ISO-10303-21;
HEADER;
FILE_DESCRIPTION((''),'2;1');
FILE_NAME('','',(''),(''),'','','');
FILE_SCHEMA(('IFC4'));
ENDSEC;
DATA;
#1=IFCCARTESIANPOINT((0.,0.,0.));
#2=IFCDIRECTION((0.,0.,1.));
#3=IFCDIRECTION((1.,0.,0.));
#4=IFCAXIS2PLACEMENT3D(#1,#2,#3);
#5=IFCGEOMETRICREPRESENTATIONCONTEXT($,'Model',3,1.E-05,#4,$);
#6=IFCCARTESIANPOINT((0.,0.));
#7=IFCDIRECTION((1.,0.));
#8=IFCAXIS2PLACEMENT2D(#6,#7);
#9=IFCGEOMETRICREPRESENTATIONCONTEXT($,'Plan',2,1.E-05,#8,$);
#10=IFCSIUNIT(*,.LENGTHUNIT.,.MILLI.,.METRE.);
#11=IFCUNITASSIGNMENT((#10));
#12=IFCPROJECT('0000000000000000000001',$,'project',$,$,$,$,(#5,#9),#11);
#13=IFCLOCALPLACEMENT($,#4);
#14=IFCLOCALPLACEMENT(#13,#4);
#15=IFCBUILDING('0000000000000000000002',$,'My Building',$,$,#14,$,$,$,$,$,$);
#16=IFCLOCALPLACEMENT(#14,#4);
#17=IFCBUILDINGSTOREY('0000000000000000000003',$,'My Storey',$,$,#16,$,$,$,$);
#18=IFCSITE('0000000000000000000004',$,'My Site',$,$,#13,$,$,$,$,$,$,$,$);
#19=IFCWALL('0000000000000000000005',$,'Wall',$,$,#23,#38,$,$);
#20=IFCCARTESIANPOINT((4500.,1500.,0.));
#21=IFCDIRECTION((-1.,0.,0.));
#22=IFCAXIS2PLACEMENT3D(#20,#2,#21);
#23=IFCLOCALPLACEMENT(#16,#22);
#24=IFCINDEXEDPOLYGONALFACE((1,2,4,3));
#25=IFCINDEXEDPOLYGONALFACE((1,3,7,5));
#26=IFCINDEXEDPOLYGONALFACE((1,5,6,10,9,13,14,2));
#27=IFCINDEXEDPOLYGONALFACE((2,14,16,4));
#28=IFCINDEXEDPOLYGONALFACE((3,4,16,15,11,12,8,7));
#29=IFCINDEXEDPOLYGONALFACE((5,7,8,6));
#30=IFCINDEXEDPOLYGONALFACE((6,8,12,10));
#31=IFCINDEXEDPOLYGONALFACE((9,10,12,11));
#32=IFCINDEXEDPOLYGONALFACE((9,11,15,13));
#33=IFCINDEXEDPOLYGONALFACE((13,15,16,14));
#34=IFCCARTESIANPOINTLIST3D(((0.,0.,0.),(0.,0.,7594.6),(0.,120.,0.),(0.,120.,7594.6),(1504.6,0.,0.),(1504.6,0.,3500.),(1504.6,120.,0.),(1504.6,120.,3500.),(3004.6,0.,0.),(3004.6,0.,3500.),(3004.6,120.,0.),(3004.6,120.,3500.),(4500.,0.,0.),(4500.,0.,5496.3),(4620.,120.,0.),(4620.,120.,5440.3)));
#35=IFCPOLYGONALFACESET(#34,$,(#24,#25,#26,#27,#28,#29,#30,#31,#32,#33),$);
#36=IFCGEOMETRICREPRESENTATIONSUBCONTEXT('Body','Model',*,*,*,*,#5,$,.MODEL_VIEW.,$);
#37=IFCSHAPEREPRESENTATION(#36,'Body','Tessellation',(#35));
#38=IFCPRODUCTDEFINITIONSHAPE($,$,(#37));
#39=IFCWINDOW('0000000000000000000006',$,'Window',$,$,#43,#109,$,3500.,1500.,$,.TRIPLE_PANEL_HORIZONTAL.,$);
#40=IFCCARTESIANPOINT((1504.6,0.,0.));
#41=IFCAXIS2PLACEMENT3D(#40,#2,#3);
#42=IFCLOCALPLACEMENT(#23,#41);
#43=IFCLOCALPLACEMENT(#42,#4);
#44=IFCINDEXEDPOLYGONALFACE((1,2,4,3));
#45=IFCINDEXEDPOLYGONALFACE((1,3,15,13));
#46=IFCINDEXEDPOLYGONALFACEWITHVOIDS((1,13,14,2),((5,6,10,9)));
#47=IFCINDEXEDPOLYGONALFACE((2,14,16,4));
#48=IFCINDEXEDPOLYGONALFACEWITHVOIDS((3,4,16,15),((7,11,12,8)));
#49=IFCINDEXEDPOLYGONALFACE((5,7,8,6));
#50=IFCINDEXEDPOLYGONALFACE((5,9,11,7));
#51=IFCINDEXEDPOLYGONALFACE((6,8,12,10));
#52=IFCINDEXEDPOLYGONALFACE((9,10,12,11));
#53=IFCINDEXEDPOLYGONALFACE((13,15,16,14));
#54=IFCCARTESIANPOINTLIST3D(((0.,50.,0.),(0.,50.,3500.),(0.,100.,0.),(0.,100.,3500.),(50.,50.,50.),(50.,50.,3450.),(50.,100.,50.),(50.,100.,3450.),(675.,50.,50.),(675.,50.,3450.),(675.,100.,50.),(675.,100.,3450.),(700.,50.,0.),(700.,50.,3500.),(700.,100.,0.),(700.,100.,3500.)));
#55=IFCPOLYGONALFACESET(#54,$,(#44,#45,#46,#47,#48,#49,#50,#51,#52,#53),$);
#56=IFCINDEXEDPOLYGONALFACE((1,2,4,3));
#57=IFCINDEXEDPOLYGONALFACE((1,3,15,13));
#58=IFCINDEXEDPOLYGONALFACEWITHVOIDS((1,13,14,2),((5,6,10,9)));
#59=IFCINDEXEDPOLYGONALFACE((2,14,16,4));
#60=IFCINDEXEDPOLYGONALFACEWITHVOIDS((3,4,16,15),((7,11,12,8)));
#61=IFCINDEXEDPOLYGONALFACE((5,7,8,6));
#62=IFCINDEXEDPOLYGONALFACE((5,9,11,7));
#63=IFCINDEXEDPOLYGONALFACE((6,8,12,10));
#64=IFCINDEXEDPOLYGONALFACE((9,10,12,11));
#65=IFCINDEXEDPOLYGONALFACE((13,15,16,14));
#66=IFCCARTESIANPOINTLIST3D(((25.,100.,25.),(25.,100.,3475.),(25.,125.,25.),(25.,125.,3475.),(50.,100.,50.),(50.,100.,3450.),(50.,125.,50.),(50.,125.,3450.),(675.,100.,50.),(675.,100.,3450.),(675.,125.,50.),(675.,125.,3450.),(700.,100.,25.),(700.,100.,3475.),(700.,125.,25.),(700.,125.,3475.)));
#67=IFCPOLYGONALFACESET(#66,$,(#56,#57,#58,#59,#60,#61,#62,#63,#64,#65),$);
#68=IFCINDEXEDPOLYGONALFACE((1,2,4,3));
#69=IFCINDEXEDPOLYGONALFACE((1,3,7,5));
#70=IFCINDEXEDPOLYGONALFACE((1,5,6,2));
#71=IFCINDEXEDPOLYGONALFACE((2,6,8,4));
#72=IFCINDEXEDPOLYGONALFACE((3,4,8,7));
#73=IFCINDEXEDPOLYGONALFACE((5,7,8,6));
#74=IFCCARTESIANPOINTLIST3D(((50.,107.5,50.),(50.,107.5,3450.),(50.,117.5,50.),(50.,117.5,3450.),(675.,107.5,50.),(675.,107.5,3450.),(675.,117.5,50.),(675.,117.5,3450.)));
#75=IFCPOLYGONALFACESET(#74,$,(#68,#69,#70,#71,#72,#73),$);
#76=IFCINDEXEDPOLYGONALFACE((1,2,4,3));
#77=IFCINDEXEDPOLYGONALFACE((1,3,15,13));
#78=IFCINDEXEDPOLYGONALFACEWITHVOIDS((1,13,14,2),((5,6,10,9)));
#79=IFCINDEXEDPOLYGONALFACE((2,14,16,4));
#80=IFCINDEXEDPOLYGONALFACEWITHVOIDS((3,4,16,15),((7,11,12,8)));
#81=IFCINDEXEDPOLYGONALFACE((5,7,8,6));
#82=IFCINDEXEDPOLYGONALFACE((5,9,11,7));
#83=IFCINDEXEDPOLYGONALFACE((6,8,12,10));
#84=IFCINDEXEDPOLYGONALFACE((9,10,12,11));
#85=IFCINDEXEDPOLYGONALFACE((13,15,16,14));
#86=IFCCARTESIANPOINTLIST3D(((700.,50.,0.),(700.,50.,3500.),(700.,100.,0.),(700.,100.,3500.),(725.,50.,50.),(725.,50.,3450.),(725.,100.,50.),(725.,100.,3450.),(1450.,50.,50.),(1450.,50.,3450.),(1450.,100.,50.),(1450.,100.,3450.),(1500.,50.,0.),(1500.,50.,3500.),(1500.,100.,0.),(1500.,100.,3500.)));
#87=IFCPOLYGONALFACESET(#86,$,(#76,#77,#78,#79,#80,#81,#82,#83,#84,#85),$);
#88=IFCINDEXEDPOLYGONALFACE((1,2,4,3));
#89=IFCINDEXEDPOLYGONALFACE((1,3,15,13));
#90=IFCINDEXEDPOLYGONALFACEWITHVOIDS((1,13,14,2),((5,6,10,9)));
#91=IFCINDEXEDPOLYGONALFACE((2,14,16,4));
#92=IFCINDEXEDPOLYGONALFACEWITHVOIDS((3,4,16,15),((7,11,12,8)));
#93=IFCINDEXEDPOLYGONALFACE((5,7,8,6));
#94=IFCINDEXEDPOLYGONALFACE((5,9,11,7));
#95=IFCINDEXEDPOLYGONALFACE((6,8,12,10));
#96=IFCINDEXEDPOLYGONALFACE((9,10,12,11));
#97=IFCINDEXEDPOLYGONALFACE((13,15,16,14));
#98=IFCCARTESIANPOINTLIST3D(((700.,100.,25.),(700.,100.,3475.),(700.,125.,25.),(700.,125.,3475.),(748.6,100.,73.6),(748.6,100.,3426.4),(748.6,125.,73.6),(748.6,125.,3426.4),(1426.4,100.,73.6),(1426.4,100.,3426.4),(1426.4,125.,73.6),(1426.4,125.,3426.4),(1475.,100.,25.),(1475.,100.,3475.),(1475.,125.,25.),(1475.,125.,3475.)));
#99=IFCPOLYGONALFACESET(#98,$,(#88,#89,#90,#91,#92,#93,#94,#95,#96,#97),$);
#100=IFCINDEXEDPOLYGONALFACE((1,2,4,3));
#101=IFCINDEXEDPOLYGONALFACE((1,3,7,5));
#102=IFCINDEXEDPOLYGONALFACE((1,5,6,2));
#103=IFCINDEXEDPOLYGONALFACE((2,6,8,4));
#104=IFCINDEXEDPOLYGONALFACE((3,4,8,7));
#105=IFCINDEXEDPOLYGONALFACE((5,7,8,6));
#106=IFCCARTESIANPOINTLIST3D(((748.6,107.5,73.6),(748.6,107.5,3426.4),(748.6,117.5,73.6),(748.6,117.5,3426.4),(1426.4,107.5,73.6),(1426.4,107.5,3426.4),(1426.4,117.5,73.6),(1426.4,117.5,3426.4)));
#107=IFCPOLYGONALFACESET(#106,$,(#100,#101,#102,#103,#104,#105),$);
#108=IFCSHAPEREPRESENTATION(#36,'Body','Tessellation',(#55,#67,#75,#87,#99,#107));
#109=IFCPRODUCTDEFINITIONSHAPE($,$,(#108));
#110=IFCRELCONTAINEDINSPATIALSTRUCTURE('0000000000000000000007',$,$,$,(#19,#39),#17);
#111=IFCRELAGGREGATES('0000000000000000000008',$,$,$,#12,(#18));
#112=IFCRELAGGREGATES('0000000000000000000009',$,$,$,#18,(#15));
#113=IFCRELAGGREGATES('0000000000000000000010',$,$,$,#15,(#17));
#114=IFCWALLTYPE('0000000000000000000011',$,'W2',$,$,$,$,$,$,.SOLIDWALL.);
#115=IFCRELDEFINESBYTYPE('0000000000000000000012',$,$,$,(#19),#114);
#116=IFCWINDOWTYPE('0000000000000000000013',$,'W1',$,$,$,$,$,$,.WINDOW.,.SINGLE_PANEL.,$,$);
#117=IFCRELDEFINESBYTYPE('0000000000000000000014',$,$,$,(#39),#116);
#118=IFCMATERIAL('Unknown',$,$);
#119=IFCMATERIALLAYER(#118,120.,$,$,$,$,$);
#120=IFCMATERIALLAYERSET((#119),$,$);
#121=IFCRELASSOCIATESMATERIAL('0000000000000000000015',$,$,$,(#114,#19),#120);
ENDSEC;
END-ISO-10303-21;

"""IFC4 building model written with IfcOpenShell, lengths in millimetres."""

from ifc_helpers import new_model, entity, si_unit, frame, origin_with_axes, origin_2d_with_axis, place, context, subcontext, project, spatial, line, indexed_curve, outline, extrude, shape, source, transform, mapped, material, layer, layer_set, layer_usage, type_object, type_shapes, element, fill, save


model = new_model("IFC4")

# Units and contexts
model_context = context("Model", 3, precision=1e-05, world=origin_with_axes())
plan_context = context("Plan", 2, precision=1e-05, world=origin_2d_with_axis())
body_context_1 = subcontext(model_context, "Body", "Model", "MODEL_VIEW")
body_context_2 = subcontext(plan_context, "Body", "Plan", "PLAN_VIEW")
ifc_project = project(units=[si_unit("LENGTHUNIT", "METRE", prefix="MILLI")], contexts=[model_context, plan_context])

# Site, building, storey
site_placement = place(None, origin_with_axes())
site = spatial("IfcSite", under=ifc_project, at=site_placement, Name="My Site")
building_placement = place(site_placement, origin_with_axes())
building = spatial("IfcBuilding", under=site, at=building_placement, Name="My Building")
storey_placement = place(building_placement, origin_with_axes())
storey = spatial("IfcBuildingStorey", under=building, at=storey_placement, Name="My Storey")

# Shared definitions
ifc_material = material(Name="Unknown")

# Shared definitions
ifc_layer_1 = layer(ifc_material, 120.0)
ifc_layer_set_1 = layer_set([ifc_layer_1])
wall_type_1 = type_object("IfcWallType", Name="W2", PredefinedType="SOLIDWALL", material=ifc_layer_set_1)
shared_shape_1 = source(origin_with_axes(), body_context_1, "Body", "SweptSolid", [
    extrude(outline(indexed_curve([(0.0, 0.0), (1500.0, 0.0), (1500.0, 3500.0), (0.0, 3500.0)], segments=[line(1, 2, 3, 4, 1)])), frame((0.0, -600.0, 0.0), z_axis=(0.0, -1.0, 0.0), x_axis=(1.0, 0.0, 0.0)), (0.0, 0.0, -1.0), 1200.0),
])
window_type_1 = type_object("IfcWindowType", Name="W1", PartitioningType="SINGLE_PANEL", PredefinedType="WINDOW")
shared_shape_2 = source(origin_with_axes(), body_context_1, "Body", "SweptSolid", [
    extrude(outline(indexed_curve([(0.0, 0.0), (700.0, 0.0), (700.0, 3500.0), (0.0, 3500.0)], segments=[line(1, 2, 3, 4, 1)]), holes=[indexed_curve([(50.0, 50.0), (675.0, 50.0), (675.0, 3450.0), (50.0, 3450.0)], segments=[line(1, 2, 3, 4, 1)])]), frame((0.0, 50.0, 0.0), z_axis=(0.0, -1.0, 0.0), x_axis=(1.0, 0.0, 0.0)), (0.0, 0.0, -1.0), 50.0),
    extrude(outline(indexed_curve([(0.0, 0.0), (675.0, 0.0), (675.0, 3450.0), (0.0, 3450.0)], segments=[line(1, 2, 3, 4, 1)]), holes=[indexed_curve([(25.0, 25.0), (650.0, 25.0), (650.0, 3425.0), (25.0, 3425.0)], segments=[line(1, 2, 3, 4, 1)])]), frame((25.0, 100.0, 25.0), z_axis=(0.0, -1.0, 0.0), x_axis=(1.0, 0.0, 0.0)), (0.0, 0.0, -1.0), 25.0),
    extrude(outline(indexed_curve([(25.0, 25.0), (650.0, 25.0), (650.0, 3425.0), (25.0, 3425.0)], segments=[line(1, 2, 3, 4, 1)])), frame((25.0, 107.5, 25.0), z_axis=(0.0, -1.0, 0.0), x_axis=(1.0, 0.0, 0.0)), (0.0, 0.0, -1.0), 10.0),
    extrude(outline(indexed_curve([(0.0, 0.0), (800.0, 0.0), (800.0, 3500.0), (0.0, 3500.0)], segments=[line(1, 2, 3, 4, 1)]), holes=[indexed_curve([(25.0, 50.0), (750.0, 50.0), (750.0, 3450.0), (25.0, 3450.0)], segments=[line(1, 2, 3, 4, 1)])]), frame((700.0, 50.0, 0.0), z_axis=(0.0, -1.0, 0.0), x_axis=(1.0, 0.0, 0.0)), (0.0, 0.0, -1.0), 50.0),
    extrude(outline(indexed_curve([(0.0, 0.0), (775.0, 0.0), (775.0, 3450.0), (0.0, 3450.0)], segments=[line(1, 2, 3, 4, 1)]), holes=[indexed_curve([(48.6, 48.6), (726.4, 48.6), (726.4, 3401.4), (48.6, 3401.4)], segments=[line(1, 2, 3, 4, 1)])]), frame((700.0, 100.0, 25.0), z_axis=(0.0, -1.0, 0.0), x_axis=(1.0, 0.0, 0.0)), (0.0, 0.0, -1.0), 25.0),
    extrude(outline(indexed_curve([(48.6, 48.6), (726.4, 48.6), (726.4, 3401.4), (48.6, 3401.4)], segments=[line(1, 2, 3, 4, 1)])), frame((700.0, 107.5, 25.0), z_axis=(0.0, -1.0, 0.0), x_axis=(1.0, 0.0, 0.0)), (0.0, 0.0, -1.0), 10.0),
])
shared_shape_3 = source(origin_with_axes(), body_context_2, "Body", "Curve2D", [
    entity("IfcIndexedPolyCurve", entity("IfcCartesianPointList2D", [[50.0, 50.0], [675.0, 50.0]])),
    entity("IfcIndexedPolyCurve", entity("IfcCartesianPointList2D", [[0.0, 100.0], [50.0, 100.0], [50.0, 50.0], [0.0, 50.0]]), [entity("IfcLineIndex", [1, 2, 3, 4, 1])]),
    entity("IfcIndexedPolyCurve", entity("IfcCartesianPointList2D", [[700.0, 100.0], [675.0, 100.0], [675.0, 50.0], [700.0, 50.0]])),
    entity("IfcIndexedPolyCurve", entity("IfcCartesianPointList2D", [[25.0, 100.0], [50.0, 100.0], [50.0, 125.0], [25.0, 125.0]]), [entity("IfcLineIndex", [1, 2, 3, 4, 1])]),
    entity("IfcIndexedPolyCurve", entity("IfcCartesianPointList2D", [[700.0, 100.0], [675.0, 100.0], [675.0, 125.0], [700.0, 125.0]]), [entity("IfcLineIndex", [1, 2, 3, 4, 1])]),
    entity("IfcIndexedPolyCurve", entity("IfcCartesianPointList2D", [[50.0, 100.0], [675.0, 100.0]])),
    entity("IfcIndexedPolyCurve", entity("IfcCartesianPointList2D", [[50.0, 125.0], [675.0, 125.0]])),
    entity("IfcIndexedPolyCurve", entity("IfcCartesianPointList2D", [[50.0, 112.5], [675.0, 112.5]])),
    entity("IfcIndexedPolyCurve", entity("IfcCartesianPointList2D", [[725.0, 50.0], [1450.0, 50.0]])),
    entity("IfcIndexedPolyCurve", entity("IfcCartesianPointList2D", [[700.0, 100.0], [725.0, 100.0], [725.0, 50.0], [700.0, 50.0]])),
    entity("IfcIndexedPolyCurve", entity("IfcCartesianPointList2D", [[1500.0, 100.0], [1450.0, 100.0], [1450.0, 50.0], [1500.0, 50.0]]), [entity("IfcLineIndex", [1, 2, 3, 4, 1])]),
    entity("IfcIndexedPolyCurve", entity("IfcCartesianPointList2D", [[700.0, 100.0], [748.6, 100.0], [748.6, 125.0], [700.0, 125.0]]), [entity("IfcLineIndex", [1, 2, 3, 4, 1])]),
    entity("IfcIndexedPolyCurve", entity("IfcCartesianPointList2D", [[1475.0, 100.0], [1426.4, 100.0], [1426.4, 125.0], [1475.0, 125.0]]), [entity("IfcLineIndex", [1, 2, 3, 4, 1])]),
    entity("IfcIndexedPolyCurve", entity("IfcCartesianPointList2D", [[748.6, 100.0], [1426.4, 100.0]])),
    entity("IfcIndexedPolyCurve", entity("IfcCartesianPointList2D", [[748.6, 125.0], [1426.4, 125.0]])),
    entity("IfcIndexedPolyCurve", entity("IfcCartesianPointList2D", [[748.6, 112.5], [1426.4, 112.5]])),
])
type_shapes(window_type_1, [shared_shape_2, shared_shape_3])

# Wall, openings, window
ifc_layer_usage_1 = layer_usage(ifc_layer_set_1, "AXIS2", "POSITIVE", 0.0)
wall_1_placement = place(storey_placement, frame((4500.0, 1500.0, 0.0), z_axis=(0.0, 0.0, 1.0), x_axis=(-1.0, 0.0, 0.0)))
wall_1 = element("IfcWall", 1, at=wall_1_placement, inside=storey, type_object=wall_type_1, material=ifc_layer_usage_1, Name="Wall", context=body_context_1, shape_type="SweptSolid", body=[
    extrude(outline(indexed_curve([(0.0, 0.0), (0.0, 120.0), (4620.0, 120.0), (4500.0, 0.0)], segments=[line(1, 2, 3, 4, 1)])), origin_with_axes(), (0.0, 0.0, 1.0), 9000.0),
])
opening_1_placement = place(wall_1_placement, frame((1504.6, 0.0, 0.0), z_axis=(0.0, 0.0, 1.0), x_axis=(1.0, 0.0, 0.0)))
opening_1 = element("IfcOpeningElement", 2, at=opening_1_placement, cuts=wall_1, PredefinedType="OPENING", context=body_context_1, shape_type="MappedRepresentation", body=[
    mapped(shared_shape_1, transform((0.0, 0.0, 0.0), x_axis=(1.0, 0.0, 0.0), y_axis=(0.0, 1.0, 0.0), z_axis=(0.0, 0.0, 1.0), scale=1.0)),
])
opening_2_placement = place(wall_1_placement, frame((4591.0, -215.7, 8702.8), z_axis=(0.0, 0.0, 1.0), x_axis=(-1.0, 0.0, 0.0)))
element("IfcOpeningElement", 3, at=opening_2_placement, cuts=wall_1, PredefinedType="OPENING", context=body_context_1, shape_type="SweptSolid", body=[
    extrude(outline(indexed_curve([(-4591.0, 1108.1), (29.0, 3262.5), (29.0, -297.2), (-4591.0, -297.2), (-4591.0, 1108.1)])), frame((0.0, 0.0, 0.0), z_axis=(0.0, -1.0, 0.0), x_axis=(-1.0, 0.0, 0.0)), (0.0, 0.0, 1.0), 500.0),
])
window_1_placement = place(opening_1_placement, frame((0.0, 0.0, 0.0), z_axis=(0.0, 0.0, 1.0), x_axis=(1.0, 0.0, 0.0)))
window_1 = element("IfcWindow", 4, at=window_1_placement, inside=storey, type_object=window_type_1, Name="Window", OverallHeight=3500.0, OverallWidth=1500.0, PartitioningType="TRIPLE_PANEL_HORIZONTAL", shapes=[
    shape(body_context_1, "Body", "MappedRepresentation", [mapped(shared_shape_2, transform((0.0, 0.0, 0.0), x_axis=(1.0, 0.0, 0.0), y_axis=(0.0, 1.0, 0.0), z_axis=(0.0, 0.0, 1.0), scale=1.0))]),
    shape(body_context_2, "Body", "MappedRepresentation", [mapped(shared_shape_3, transform((0.0, 0.0, 0.0), x_axis=(1.0, 0.0, 0.0), y_axis=(0.0, 1.0, 0.0), z_axis=(0.0, 0.0, 1.0), scale=1.0))]),
])
fill(opening_1, window_1)

save(model, "model.ifc")
